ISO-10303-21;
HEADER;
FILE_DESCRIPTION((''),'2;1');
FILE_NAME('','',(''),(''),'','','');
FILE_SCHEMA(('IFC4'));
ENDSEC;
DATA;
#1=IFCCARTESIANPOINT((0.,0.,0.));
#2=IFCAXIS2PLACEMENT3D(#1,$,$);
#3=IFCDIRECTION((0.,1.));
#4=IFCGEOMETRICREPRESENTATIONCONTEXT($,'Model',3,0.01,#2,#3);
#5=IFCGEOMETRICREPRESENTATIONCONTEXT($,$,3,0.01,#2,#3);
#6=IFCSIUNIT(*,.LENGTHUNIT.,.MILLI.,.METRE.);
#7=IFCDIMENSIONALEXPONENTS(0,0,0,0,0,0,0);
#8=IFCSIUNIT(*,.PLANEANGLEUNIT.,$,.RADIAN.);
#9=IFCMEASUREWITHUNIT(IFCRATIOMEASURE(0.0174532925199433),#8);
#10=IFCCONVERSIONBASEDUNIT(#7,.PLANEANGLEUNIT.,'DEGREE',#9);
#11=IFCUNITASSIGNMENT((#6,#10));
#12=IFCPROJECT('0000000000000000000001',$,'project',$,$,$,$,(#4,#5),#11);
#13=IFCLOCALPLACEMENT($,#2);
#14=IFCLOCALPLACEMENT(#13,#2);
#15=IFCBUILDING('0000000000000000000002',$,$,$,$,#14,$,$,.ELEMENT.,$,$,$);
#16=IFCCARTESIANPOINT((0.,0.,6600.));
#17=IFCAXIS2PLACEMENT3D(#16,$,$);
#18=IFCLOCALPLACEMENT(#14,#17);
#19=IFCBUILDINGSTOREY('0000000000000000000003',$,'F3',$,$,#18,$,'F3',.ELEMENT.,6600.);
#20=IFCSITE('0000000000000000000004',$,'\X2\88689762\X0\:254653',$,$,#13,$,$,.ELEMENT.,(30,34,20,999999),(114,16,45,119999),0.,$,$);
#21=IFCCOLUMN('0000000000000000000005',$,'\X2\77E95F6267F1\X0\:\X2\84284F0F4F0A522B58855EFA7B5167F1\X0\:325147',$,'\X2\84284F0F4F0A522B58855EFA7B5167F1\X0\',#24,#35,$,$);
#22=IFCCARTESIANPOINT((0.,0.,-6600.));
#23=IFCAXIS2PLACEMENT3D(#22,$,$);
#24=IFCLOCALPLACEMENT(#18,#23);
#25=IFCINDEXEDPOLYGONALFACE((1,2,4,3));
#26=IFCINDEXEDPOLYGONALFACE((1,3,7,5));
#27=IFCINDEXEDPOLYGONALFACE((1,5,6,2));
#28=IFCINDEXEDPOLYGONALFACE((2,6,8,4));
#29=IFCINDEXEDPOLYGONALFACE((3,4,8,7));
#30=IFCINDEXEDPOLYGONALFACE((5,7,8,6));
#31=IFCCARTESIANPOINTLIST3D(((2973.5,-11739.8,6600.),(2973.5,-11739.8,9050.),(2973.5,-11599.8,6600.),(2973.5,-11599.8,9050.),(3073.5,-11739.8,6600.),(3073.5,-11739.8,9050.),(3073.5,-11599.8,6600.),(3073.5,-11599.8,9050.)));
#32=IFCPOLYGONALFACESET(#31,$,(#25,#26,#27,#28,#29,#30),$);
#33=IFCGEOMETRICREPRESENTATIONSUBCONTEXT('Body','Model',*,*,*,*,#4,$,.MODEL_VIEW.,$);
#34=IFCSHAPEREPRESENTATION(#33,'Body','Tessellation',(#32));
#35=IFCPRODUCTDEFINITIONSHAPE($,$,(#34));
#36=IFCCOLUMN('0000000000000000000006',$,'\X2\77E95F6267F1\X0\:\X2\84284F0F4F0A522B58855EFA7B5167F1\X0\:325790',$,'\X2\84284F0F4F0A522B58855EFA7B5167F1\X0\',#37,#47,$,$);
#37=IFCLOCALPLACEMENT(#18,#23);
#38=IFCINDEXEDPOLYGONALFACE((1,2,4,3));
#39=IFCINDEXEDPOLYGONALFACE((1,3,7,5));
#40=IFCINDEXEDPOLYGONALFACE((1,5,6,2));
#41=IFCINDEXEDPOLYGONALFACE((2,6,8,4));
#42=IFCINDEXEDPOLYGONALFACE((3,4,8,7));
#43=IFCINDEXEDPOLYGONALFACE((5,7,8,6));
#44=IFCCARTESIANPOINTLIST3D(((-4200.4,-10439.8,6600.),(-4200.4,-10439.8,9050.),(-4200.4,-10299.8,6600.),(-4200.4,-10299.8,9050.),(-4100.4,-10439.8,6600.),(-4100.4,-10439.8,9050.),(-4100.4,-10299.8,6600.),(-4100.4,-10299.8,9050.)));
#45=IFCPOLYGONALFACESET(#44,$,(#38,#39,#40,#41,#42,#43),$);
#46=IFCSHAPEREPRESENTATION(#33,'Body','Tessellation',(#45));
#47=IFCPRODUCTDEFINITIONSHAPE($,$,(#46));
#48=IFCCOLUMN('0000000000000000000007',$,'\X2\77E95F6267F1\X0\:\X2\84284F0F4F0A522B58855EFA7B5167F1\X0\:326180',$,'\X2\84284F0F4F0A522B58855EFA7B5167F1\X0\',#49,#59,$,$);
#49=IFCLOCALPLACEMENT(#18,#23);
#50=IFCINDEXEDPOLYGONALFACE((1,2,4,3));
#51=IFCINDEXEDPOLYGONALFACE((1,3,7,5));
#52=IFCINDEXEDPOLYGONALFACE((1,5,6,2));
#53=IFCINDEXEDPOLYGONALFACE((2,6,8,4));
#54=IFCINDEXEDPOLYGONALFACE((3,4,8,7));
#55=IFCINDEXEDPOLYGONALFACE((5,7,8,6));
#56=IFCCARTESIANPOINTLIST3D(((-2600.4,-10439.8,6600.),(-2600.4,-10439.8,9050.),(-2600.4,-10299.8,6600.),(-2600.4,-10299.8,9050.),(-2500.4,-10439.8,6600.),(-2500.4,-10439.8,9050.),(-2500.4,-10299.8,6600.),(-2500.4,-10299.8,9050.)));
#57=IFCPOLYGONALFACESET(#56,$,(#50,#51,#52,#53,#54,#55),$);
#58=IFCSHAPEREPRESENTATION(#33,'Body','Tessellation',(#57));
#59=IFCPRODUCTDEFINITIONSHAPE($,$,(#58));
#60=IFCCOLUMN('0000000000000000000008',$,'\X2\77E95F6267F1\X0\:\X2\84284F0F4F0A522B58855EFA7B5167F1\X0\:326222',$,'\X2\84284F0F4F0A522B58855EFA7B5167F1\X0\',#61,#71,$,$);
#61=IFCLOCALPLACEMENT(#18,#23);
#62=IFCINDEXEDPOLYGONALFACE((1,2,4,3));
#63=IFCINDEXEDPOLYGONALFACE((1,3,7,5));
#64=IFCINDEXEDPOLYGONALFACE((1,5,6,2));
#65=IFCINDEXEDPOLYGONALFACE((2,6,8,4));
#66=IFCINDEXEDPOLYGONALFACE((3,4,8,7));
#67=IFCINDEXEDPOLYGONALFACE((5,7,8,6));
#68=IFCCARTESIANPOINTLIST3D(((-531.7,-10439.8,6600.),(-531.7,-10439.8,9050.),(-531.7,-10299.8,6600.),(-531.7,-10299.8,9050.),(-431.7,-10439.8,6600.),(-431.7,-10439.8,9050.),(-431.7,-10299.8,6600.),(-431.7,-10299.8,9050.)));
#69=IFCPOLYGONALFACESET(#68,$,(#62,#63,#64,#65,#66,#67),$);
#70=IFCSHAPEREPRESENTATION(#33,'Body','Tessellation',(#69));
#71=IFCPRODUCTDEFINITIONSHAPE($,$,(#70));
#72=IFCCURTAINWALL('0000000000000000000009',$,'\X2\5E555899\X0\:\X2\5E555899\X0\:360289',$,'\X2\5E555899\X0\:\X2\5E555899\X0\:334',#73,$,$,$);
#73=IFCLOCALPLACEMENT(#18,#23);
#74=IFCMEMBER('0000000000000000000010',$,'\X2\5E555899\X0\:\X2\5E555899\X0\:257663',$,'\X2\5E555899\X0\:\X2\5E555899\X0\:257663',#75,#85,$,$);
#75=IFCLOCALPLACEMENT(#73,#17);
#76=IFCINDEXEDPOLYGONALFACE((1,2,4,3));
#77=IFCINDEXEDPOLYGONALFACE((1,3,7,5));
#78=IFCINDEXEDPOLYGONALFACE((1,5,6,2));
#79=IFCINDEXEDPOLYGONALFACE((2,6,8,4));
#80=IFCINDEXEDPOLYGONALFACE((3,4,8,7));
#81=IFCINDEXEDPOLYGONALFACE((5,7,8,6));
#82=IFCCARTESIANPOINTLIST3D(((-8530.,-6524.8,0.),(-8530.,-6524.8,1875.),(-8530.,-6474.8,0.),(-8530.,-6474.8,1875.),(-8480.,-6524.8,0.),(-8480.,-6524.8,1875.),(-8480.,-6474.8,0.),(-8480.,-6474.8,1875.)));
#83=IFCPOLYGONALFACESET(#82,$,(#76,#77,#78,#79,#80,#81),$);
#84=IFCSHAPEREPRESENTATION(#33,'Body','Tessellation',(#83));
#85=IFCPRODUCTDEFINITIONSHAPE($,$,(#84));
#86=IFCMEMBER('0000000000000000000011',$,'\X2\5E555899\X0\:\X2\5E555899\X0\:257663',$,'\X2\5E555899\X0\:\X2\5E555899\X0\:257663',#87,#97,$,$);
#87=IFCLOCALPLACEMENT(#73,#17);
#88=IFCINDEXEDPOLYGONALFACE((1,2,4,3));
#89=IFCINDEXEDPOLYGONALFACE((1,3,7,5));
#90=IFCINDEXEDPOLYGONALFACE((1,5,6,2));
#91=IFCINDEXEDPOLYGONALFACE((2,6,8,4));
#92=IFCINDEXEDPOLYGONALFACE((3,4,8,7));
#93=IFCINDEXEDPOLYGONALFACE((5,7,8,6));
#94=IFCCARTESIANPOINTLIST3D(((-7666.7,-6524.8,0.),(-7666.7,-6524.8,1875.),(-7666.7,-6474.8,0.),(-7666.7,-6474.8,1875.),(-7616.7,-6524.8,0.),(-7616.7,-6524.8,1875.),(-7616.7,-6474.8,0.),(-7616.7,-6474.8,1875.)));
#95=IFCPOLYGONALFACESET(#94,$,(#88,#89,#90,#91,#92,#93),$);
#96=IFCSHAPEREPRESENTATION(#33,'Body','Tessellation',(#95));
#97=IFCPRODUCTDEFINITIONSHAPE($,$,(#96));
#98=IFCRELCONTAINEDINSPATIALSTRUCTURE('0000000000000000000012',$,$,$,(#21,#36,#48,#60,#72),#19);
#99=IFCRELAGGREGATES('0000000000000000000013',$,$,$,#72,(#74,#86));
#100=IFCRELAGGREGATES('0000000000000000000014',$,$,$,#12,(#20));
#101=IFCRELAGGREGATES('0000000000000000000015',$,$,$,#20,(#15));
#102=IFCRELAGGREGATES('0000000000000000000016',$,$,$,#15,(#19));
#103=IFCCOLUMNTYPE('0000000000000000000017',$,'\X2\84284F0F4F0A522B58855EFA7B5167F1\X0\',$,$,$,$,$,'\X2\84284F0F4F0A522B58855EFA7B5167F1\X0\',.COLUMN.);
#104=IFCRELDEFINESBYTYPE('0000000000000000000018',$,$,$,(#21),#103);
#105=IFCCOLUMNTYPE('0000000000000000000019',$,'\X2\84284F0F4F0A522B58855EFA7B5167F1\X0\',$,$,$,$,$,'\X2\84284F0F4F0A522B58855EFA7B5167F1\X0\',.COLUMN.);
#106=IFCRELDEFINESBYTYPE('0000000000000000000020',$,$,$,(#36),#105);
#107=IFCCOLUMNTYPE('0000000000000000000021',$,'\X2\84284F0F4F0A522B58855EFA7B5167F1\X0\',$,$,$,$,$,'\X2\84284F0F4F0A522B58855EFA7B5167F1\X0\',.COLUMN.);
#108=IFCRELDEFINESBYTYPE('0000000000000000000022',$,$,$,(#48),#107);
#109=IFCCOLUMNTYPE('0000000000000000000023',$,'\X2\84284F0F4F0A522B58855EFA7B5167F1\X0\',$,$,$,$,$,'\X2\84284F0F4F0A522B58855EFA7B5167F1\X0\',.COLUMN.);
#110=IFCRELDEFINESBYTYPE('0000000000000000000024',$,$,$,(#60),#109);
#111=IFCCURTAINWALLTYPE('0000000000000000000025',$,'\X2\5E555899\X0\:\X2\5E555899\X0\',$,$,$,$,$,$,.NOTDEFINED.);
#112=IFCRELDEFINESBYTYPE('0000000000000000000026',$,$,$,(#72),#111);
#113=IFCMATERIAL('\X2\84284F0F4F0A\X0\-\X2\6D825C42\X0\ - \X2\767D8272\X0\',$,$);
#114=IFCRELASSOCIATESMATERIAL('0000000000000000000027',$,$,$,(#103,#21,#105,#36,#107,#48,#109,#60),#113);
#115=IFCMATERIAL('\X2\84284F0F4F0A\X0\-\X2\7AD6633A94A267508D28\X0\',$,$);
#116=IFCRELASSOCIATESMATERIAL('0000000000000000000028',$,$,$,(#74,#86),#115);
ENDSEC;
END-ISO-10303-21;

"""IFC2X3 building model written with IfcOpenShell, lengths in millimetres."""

from ifc_helpers import new_model, entity, si_unit, converted_unit, direction, frame, frame_2d, origin, origin_2d_with_axis, place, context, subcontext, project, spatial, rectangle, extrude, source, transform, mapped, material, type_object, type_shapes, element, aggregate, save


model = new_model("IFC2X3")

# Units and contexts
model_context = context("Model", 3, precision=0.01, world=origin(), true_north=direction((0.0, 1.0)))
context_of_model = context(None, 3, precision=0.01, world=origin(), true_north=direction((0.0, 1.0)))
body_context = subcontext(model_context, "Body", "Model", "MODEL_VIEW")
ifc_project = project(units=[si_unit("LENGTHUNIT", "METRE", prefix="MILLI"), converted_unit("PLANEANGLEUNIT", "DEGREE", entity("IfcRatioMeasure", 0.0174532925199433), si_unit("PLANEANGLEUNIT", "RADIAN"), dimensions=[0, 0, 0, 0, 0, 0, 0])], contexts=[model_context, context_of_model])

# Site, building, storey
site_placement = place(None, origin())
site = spatial("IfcSite", under=ifc_project, at=site_placement, Name="表面:254653", CompositionType="ELEMENT", RefLatitude=(30, 34, 20, 999999), RefLongitude=(114, 16, 45, 119999), RefElevation=0.0)
building_placement = place(site_placement, origin())
building = spatial("IfcBuilding", under=site, at=building_placement, CompositionType="ELEMENT")
storey_placement = place(building_placement, frame((0.0, 0.0, 6600.0)))
storey = spatial("IfcBuildingStorey", under=building, at=storey_placement, Name="F3", LongName="F3", CompositionType="ELEMENT", Elevation=6600.0)

# Columns
ifc_material_1 = material(Name="萨伏伊-涂层 - 白色")
column_type_1 = type_object("IfcColumnType", Name="萨伏伊别墅建筑柱", ElementType="萨伏伊别墅建筑柱", PredefinedType="COLUMN", material=ifc_material_1)
shared_shape_1 = source(origin(), body_context, "Body", "SweptSolid", [
    extrude(rectangle(XDim=140.0, YDim=100.0, at=origin_2d_with_axis()), frame((3023.5, -11669.8, 6600.0), z_axis=(0.0, 0.0, 1.0), x_axis=(0.0, -1.0, 0.0)), (0.0, 0.0, 1.0), 2450.0),
])
type_shapes(column_type_1, [shared_shape_1])
column_1_placement = place(storey_placement, frame((0.0, 0.0, -6600.0)))
element("IfcColumn", 1, at=column_1_placement, inside=storey, type_object=column_type_1, material=ifc_material_1, Name="矩形柱:萨伏伊别墅建筑柱:325147", ObjectType="萨伏伊别墅建筑柱", context=body_context, shape_type="MappedRepresentation", body=[
    mapped(shared_shape_1, transform((0.0, 0.0, 0.0), scale=1.0)),
])
column_type_2 = type_object("IfcColumnType", Name="萨伏伊别墅建筑柱", ElementType="萨伏伊别墅建筑柱", PredefinedType="COLUMN", material=ifc_material_1)
shared_shape_2 = source(origin(), body_context, "Body", "SweptSolid", [
    extrude(rectangle(XDim=140.0, YDim=100.0, at=frame_2d((0.0, 0.0), x_axis=(1.0, 0.0))), frame((-4150.4, -10369.8, 6600.0), z_axis=(0.0, 0.0, 1.0), x_axis=(0.0, -1.0, 0.0)), (0.0, 0.0, 1.0), 2450.0),
])
type_shapes(column_type_2, [shared_shape_2])
column_2_placement = place(storey_placement, frame((0.0, 0.0, -6600.0)))
element("IfcColumn", 2, at=column_2_placement, inside=storey, type_object=column_type_2, material=ifc_material_1, Name="矩形柱:萨伏伊别墅建筑柱:325790", ObjectType="萨伏伊别墅建筑柱", context=body_context, shape_type="MappedRepresentation", body=[
    mapped(shared_shape_2, transform((0.0, 0.0, 0.0), scale=1.0)),
])
column_type_3 = type_object("IfcColumnType", Name="萨伏伊别墅建筑柱", ElementType="萨伏伊别墅建筑柱", PredefinedType="COLUMN", material=ifc_material_1)
shared_shape_3 = source(origin(), body_context, "Body", "SweptSolid", [
    extrude(rectangle(XDim=140.0, YDim=100.0, at=origin_2d_with_axis()), frame((-2550.4, -10369.8, 6600.0), z_axis=(0.0, 0.0, 1.0), x_axis=(0.0, -1.0, 0.0)), (0.0, 0.0, 1.0), 2450.0),
])
type_shapes(column_type_3, [shared_shape_3])
column_3_placement = place(storey_placement, frame((0.0, 0.0, -6600.0)))
element("IfcColumn", 3, at=column_3_placement, inside=storey, type_object=column_type_3, material=ifc_material_1, Name="矩形柱:萨伏伊别墅建筑柱:326180", ObjectType="萨伏伊别墅建筑柱", context=body_context, shape_type="MappedRepresentation", body=[
    mapped(shared_shape_3, transform((0.0, 0.0, 0.0), scale=1.0)),
])
column_type_4 = type_object("IfcColumnType", Name="萨伏伊别墅建筑柱", ElementType="萨伏伊别墅建筑柱", PredefinedType="COLUMN", material=ifc_material_1)
shared_shape_4 = source(origin(), body_context, "Body", "SweptSolid", [
    extrude(rectangle(XDim=140.0, YDim=100.0, at=frame_2d((0.0, 0.0), x_axis=(1.0, 0.0))), frame((-481.7, -10369.8, 6600.0), z_axis=(0.0, 0.0, 1.0), x_axis=(0.0, -1.0, 0.0)), (0.0, 0.0, 1.0), 2450.0),
])
type_shapes(column_type_4, [shared_shape_4])
column_4_placement = place(storey_placement, frame((0.0, 0.0, -6600.0)))
element("IfcColumn", 4, at=column_4_placement, inside=storey, type_object=column_type_4, material=ifc_material_1, Name="矩形柱:萨伏伊别墅建筑柱:326222", ObjectType="萨伏伊别墅建筑柱", context=body_context, shape_type="MappedRepresentation", body=[
    mapped(shared_shape_4, transform((0.0, 0.0, 0.0), scale=1.0)),
])

# Curtain wall, members
curtain_wall_type = type_object("IfcCurtainWallType", Name="幕墙:幕墙", PredefinedType="NOTDEFINED")
curtain_wall_placement = place(storey_placement, frame((0.0, 0.0, -6600.0)))
curtain_wall = element("IfcCurtainWall", 5, at=curtain_wall_placement, inside=storey, type_object=curtain_wall_type, Name="幕墙:幕墙:360289", ObjectType="幕墙:幕墙:334")
ifc_material_2 = material(Name="萨伏伊-竖挺钢材质")
member_1_placement = place(curtain_wall_placement, frame((0.0, 0.0, 6600.0)))
member_1 = element("IfcMember", 6, at=member_1_placement, material=ifc_material_2, Name="幕墙:幕墙:257663", ObjectType="幕墙:幕墙:257663", context=body_context, shape_type="SweptSolid", body=[
    extrude(rectangle(XDim=50.0, YDim=50.0, at=origin_2d_with_axis()), frame((-8505.0, -6499.8, 0.0), z_axis=(0.0, 0.0, 1.0), x_axis=(-1.0, 0.0, 0.0)), (0.0, 0.0, 1.0), 1875.0),
])
member_2_placement = place(curtain_wall_placement, frame((0.0, 0.0, 6600.0)))
member_2 = element("IfcMember", 7, at=member_2_placement, material=ifc_material_2, Name="幕墙:幕墙:257663", ObjectType="幕墙:幕墙:257663", context=body_context, shape_type="SweptSolid", body=[
    extrude(rectangle(XDim=50.0, YDim=50.0, at=frame_2d((0.0, 0.0), x_axis=(1.0, 0.0))), frame((-7641.7, -6499.8, 0.0), z_axis=(0.0, 0.0, 1.0), x_axis=(-1.0, 0.0, 0.0)), (0.0, 0.0, 1.0), 1875.0),
])
aggregate(curtain_wall, [member_1, member_2])

save(model, "model.ifc")
